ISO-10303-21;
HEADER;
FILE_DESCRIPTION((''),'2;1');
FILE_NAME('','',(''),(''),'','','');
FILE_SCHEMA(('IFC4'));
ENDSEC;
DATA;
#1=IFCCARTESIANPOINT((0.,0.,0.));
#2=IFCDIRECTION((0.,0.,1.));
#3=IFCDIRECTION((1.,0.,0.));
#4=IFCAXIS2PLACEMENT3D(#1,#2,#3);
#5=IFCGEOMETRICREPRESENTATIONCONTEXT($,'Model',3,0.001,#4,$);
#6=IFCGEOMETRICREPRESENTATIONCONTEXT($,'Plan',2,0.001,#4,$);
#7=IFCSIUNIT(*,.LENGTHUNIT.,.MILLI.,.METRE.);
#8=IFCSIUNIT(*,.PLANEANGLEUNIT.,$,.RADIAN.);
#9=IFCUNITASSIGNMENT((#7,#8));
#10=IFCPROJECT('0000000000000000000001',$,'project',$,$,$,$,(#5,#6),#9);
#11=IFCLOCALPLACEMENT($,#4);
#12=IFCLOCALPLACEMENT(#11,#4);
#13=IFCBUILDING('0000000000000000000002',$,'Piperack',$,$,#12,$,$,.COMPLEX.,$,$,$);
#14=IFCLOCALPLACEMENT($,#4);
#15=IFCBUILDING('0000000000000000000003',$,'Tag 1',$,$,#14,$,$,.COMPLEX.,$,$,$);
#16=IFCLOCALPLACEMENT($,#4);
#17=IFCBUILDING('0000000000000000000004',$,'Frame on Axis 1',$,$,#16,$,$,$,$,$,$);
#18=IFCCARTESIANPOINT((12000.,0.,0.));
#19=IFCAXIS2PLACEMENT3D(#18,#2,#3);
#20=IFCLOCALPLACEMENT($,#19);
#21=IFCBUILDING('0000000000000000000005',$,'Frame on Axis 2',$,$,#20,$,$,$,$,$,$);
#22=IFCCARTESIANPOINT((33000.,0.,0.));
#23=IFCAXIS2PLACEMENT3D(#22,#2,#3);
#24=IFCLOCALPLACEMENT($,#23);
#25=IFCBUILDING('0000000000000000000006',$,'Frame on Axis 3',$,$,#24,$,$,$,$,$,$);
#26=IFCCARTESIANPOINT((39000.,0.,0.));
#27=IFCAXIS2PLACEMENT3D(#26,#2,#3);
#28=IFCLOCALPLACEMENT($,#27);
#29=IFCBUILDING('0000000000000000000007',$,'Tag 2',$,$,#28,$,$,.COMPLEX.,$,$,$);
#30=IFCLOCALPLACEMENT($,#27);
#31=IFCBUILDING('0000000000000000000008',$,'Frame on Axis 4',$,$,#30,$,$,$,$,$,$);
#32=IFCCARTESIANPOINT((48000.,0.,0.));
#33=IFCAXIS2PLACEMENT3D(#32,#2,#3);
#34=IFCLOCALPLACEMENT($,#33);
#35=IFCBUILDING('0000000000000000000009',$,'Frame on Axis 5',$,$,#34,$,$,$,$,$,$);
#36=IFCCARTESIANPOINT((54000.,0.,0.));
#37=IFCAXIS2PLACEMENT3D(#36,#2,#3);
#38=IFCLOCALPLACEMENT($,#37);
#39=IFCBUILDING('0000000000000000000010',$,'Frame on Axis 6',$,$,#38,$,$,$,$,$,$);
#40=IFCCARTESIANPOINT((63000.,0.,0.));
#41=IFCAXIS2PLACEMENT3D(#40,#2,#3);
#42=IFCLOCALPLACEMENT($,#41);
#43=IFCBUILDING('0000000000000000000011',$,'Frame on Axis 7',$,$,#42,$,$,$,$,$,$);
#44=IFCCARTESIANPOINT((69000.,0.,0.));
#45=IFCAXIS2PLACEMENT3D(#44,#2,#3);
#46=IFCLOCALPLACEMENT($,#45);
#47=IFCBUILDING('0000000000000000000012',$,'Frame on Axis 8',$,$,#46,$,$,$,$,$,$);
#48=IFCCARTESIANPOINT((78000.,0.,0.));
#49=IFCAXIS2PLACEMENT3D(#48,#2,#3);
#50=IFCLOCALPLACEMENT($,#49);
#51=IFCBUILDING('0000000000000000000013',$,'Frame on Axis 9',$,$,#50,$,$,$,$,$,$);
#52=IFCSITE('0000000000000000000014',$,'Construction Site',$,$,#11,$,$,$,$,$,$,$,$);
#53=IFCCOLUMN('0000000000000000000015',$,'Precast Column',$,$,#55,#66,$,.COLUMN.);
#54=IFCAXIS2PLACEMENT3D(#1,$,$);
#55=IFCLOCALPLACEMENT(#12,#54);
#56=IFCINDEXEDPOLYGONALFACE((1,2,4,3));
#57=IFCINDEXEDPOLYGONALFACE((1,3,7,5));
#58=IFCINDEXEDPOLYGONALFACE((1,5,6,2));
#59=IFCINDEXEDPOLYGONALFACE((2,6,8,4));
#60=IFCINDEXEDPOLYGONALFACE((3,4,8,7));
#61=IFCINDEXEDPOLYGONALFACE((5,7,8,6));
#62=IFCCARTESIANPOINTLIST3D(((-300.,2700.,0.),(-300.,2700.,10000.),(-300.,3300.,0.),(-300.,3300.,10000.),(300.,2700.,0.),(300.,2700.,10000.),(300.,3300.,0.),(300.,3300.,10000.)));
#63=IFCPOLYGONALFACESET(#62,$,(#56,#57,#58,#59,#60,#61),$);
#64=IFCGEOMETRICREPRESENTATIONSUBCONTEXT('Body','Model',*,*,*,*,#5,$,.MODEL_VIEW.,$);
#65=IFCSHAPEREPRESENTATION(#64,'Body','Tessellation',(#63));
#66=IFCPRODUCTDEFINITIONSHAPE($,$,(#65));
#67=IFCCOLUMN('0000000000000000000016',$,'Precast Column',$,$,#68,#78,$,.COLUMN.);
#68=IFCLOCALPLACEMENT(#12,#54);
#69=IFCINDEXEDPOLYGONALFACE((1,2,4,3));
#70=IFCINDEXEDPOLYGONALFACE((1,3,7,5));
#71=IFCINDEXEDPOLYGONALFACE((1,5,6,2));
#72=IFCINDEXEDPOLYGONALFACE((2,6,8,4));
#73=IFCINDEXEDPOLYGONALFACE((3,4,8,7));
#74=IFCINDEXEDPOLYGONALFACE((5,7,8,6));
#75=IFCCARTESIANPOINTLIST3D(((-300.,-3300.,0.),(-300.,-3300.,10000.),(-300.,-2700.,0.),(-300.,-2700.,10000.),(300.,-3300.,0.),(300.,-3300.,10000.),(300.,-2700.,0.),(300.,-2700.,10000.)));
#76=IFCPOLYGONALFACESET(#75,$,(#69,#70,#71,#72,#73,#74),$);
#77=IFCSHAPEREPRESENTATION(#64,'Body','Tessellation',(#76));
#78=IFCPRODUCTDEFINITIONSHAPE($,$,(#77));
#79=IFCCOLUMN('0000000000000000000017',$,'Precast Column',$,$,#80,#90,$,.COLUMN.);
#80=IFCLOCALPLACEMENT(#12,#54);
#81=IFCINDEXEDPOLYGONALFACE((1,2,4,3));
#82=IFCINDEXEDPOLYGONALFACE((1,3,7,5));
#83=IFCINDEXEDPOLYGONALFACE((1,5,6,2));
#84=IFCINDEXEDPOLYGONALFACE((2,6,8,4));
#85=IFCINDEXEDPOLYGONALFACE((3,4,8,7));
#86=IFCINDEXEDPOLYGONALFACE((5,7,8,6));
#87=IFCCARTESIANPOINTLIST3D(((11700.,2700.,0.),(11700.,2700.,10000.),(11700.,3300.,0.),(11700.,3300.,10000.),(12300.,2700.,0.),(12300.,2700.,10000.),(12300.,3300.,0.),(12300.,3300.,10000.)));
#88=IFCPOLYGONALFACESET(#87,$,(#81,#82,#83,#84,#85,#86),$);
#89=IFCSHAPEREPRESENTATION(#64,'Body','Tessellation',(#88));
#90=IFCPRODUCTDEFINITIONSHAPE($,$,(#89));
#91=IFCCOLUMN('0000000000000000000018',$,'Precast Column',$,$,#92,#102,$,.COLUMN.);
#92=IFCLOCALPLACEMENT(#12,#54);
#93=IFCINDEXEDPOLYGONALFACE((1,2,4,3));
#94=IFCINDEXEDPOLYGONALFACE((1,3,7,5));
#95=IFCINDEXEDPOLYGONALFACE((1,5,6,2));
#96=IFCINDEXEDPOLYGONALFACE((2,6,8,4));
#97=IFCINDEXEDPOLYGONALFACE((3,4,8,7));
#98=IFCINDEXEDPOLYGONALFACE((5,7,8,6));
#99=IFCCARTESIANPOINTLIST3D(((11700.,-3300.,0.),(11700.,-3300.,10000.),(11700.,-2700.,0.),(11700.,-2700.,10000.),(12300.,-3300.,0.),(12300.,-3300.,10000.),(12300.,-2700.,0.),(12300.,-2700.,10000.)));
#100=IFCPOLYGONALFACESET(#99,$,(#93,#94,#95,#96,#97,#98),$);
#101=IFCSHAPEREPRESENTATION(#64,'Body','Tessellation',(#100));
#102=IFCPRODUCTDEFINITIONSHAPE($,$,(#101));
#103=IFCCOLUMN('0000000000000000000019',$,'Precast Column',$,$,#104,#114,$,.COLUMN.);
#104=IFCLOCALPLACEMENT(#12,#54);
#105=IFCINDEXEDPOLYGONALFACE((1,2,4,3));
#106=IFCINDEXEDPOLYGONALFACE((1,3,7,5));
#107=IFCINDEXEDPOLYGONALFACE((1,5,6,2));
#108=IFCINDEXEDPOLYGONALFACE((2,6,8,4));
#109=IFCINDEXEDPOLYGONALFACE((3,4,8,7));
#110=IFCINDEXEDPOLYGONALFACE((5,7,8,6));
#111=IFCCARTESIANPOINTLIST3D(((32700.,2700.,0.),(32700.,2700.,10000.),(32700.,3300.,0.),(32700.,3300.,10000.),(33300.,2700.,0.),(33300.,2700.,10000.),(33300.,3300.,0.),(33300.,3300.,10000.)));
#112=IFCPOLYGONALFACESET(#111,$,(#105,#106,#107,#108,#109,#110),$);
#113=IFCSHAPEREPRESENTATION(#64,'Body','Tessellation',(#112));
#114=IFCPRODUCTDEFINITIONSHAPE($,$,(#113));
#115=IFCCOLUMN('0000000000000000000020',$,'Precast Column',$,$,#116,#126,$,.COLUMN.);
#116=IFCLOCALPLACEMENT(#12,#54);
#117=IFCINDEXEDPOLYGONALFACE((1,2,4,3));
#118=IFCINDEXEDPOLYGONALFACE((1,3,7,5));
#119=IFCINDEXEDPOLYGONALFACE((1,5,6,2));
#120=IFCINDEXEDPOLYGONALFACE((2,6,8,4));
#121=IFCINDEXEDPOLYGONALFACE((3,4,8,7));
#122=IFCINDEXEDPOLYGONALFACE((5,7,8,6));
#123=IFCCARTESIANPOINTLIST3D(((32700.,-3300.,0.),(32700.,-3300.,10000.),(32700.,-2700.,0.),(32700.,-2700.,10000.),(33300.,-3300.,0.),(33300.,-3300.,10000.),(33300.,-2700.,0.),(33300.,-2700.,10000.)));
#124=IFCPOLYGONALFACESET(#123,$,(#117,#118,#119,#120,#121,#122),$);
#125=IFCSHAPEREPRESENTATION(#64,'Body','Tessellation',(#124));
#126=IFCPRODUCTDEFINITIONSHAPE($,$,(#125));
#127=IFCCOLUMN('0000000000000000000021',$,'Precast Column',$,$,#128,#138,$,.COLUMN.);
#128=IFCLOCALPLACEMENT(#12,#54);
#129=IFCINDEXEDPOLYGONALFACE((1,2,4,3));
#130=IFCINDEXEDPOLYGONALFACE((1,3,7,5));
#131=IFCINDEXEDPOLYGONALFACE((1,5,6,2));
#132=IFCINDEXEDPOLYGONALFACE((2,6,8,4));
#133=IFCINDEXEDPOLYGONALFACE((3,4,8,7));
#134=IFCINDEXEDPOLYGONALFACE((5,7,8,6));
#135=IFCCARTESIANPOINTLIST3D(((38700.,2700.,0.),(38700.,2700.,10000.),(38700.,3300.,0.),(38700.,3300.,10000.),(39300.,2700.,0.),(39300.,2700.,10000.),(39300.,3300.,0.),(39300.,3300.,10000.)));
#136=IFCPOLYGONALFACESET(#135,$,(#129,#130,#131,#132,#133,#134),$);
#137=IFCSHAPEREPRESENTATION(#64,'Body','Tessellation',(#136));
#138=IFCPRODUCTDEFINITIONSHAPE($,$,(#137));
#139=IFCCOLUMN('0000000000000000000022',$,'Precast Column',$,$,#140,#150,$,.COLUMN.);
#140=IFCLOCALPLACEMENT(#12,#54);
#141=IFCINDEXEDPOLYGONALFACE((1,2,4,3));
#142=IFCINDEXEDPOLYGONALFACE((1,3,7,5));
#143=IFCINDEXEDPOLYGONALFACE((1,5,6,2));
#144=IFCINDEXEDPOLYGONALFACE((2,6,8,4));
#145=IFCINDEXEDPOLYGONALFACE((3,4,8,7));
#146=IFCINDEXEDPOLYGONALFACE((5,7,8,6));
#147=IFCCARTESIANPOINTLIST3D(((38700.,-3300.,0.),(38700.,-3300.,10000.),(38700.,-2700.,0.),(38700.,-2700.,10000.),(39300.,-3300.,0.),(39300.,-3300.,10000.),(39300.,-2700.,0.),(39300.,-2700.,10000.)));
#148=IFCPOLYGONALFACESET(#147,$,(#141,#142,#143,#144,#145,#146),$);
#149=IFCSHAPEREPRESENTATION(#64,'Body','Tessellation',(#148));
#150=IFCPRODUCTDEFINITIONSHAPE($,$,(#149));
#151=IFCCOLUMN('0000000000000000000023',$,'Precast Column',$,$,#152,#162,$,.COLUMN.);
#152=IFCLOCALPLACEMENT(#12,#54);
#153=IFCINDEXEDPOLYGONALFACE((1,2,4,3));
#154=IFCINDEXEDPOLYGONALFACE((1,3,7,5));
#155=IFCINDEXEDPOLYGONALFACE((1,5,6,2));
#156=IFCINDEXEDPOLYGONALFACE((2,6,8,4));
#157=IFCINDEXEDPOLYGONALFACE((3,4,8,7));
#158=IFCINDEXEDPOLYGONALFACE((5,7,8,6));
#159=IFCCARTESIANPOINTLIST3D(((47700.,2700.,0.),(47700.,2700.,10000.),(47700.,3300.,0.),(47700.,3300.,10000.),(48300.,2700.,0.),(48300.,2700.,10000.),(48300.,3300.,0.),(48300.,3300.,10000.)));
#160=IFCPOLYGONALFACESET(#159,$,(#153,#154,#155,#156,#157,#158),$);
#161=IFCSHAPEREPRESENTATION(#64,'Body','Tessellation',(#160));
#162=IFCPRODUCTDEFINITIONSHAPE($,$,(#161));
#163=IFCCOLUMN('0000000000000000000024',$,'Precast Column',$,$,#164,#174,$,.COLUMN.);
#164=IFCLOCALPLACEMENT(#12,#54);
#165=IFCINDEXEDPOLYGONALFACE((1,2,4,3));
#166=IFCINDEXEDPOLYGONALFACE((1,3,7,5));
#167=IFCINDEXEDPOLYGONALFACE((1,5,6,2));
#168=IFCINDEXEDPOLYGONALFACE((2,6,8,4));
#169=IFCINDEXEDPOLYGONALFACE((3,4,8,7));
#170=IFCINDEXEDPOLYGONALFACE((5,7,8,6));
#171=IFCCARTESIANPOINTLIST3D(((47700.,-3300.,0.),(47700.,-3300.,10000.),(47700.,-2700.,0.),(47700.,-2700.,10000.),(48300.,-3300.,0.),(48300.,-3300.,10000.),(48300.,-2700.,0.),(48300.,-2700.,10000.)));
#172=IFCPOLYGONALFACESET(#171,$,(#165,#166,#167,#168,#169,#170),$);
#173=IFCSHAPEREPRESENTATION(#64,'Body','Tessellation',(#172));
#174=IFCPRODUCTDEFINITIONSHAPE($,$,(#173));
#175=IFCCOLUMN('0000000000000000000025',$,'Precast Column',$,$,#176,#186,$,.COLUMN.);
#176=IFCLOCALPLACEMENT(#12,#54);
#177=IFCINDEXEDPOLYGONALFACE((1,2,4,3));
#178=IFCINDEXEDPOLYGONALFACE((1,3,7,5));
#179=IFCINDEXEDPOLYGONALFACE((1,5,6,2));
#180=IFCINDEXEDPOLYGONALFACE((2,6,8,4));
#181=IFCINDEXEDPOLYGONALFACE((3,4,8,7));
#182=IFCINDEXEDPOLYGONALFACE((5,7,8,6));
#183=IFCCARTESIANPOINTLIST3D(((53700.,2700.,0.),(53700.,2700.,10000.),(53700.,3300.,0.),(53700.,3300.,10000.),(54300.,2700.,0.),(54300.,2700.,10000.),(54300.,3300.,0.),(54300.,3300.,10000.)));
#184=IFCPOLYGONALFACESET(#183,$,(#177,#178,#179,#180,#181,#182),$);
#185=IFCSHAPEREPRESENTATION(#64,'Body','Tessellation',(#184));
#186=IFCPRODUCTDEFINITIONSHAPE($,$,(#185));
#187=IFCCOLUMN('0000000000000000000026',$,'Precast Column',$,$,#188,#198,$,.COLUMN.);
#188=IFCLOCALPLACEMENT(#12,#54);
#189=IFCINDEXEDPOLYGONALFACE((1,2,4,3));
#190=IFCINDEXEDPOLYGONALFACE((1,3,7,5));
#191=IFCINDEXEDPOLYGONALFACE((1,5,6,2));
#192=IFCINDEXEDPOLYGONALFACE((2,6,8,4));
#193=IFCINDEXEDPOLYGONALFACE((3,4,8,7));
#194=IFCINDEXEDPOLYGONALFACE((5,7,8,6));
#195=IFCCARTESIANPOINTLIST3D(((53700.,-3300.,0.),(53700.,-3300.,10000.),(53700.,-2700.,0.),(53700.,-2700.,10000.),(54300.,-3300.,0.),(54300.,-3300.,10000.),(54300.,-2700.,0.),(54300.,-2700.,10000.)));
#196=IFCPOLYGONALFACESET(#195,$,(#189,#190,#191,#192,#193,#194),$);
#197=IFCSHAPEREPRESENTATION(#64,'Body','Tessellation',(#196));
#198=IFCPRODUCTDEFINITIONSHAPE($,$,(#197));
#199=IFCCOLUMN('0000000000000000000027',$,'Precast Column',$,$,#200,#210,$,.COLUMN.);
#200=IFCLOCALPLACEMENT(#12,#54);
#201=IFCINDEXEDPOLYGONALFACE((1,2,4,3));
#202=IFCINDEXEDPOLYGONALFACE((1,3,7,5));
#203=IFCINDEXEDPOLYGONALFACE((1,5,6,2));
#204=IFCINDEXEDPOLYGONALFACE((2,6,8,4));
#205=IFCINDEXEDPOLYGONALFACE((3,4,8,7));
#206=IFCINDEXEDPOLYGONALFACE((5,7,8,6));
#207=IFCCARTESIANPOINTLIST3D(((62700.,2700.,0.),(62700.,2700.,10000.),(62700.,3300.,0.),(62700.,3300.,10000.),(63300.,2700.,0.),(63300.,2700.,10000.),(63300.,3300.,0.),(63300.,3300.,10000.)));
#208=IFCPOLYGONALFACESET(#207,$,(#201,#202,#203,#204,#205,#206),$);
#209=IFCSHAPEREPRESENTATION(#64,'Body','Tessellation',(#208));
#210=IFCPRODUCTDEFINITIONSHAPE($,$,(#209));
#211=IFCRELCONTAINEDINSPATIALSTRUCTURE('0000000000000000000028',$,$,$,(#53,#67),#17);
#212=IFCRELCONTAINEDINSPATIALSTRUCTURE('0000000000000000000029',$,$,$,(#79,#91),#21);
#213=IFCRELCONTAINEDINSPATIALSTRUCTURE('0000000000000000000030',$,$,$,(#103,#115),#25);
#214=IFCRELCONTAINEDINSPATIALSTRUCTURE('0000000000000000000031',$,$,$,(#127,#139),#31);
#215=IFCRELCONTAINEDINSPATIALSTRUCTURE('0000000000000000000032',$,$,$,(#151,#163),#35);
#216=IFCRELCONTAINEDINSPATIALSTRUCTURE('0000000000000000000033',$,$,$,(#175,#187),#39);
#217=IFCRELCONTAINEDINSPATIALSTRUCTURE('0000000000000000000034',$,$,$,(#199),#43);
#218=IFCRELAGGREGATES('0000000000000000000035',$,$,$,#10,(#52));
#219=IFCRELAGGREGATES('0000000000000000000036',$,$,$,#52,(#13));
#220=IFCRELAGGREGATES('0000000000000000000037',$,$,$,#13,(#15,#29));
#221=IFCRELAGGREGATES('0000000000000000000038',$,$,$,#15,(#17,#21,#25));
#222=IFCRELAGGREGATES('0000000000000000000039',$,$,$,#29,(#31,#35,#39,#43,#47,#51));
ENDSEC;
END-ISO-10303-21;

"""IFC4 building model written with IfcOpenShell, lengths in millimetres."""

from ifc_helpers import new_model, si_unit, frame, origin_with_axes, place, context, subcontext, project, spatial, rectangle, extrude, element, save


model = new_model("IFC4")

# Units and contexts
model_context = context("Model", 3, precision=0.001, world=origin_with_axes())
plan_context = context("Plan", 2, precision=0.001, world=origin_with_axes())
body_context = subcontext(model_context, "Body", "Model", "MODEL_VIEW")
ifc_project = project(units=[si_unit("LENGTHUNIT", "METRE", prefix="MILLI"), si_unit("PLANEANGLEUNIT", "RADIAN")], contexts=[model_context, plan_context])

# Site, buildings
site_placement = place(None, origin_with_axes())
site = spatial("IfcSite", under=ifc_project, at=site_placement, Name="Construction Site")
building_1_placement = place(site_placement, origin_with_axes())
building_1 = spatial("IfcBuilding", under=site, at=building_1_placement, Name="Piperack", CompositionType="COMPLEX")
building_2_placement = place(None, origin_with_axes())
building_2 = spatial("IfcBuilding", under=building_1, at=building_2_placement, Name="Tag 1", CompositionType="COMPLEX")
building_3_placement = place(None, origin_with_axes())
building_3 = spatial("IfcBuilding", under=building_2, at=building_3_placement, Name="Frame on Axis 1")

# Columns
for number, where, z_axis, x_axis, name in (
    (1, (0.0, 3000.0, 0.0), (0.0, 0.0, 1.0), (1.0, 0.0, 0.0), "Precast Column"),
    (2, (0.0, -3000.0, 0.0), (0.0, 0.0, 1.0), (1.0, 0.0, 0.0), "Precast Column"),
):
    element("IfcColumn", number, at=place(building_3_placement, frame(where, z_axis=z_axis, x_axis=x_axis)), inside=building_3, Name=name, PredefinedType="COLUMN", context=body_context, shape_type="SweptSolid", body=[
        extrude(rectangle(XDim=600.0, YDim=600.0), None, (0.0, 0.0, 1.0), 10000.0),
    ])

# Shared definitions
building_4_placement = place(None, frame((12000.0, 0.0, 0.0), z_axis=(0.0, 0.0, 1.0), x_axis=(1.0, 0.0, 0.0)))
building_4 = spatial("IfcBuilding", under=building_2, at=building_4_placement, Name="Frame on Axis 2")

# Columns
for number, where, z_axis, x_axis, name in (
    (3, (0.0, 3000.0, 0.0), (0.0, 0.0, 1.0), (1.0, 0.0, 0.0), "Precast Column"),
    (4, (0.0, -3000.0, 0.0), (0.0, 0.0, 1.0), (1.0, 0.0, 0.0), "Precast Column"),
):
    element("IfcColumn", number, at=place(building_4_placement, frame(where, z_axis=z_axis, x_axis=x_axis)), inside=building_4, Name=name, PredefinedType="COLUMN", context=body_context, shape_type="SweptSolid", body=[
        extrude(rectangle(XDim=600.0, YDim=600.0), None, (0.0, 0.0, 1.0), 10000.0),
    ])

# Shared definitions
building_5_placement = place(None, frame((33000.0, 0.0, 0.0), z_axis=(0.0, 0.0, 1.0), x_axis=(1.0, 0.0, 0.0)))
building_5 = spatial("IfcBuilding", under=building_2, at=building_5_placement, Name="Frame on Axis 3")

# Columns
for number, where, z_axis, x_axis, name in (
    (5, (0.0, 3000.0, 0.0), (0.0, 0.0, 1.0), (1.0, 0.0, 0.0), "Precast Column"),
    (6, (0.0, -3000.0, 0.0), (0.0, 0.0, 1.0), (1.0, 0.0, 0.0), "Precast Column"),
):
    element("IfcColumn", number, at=place(building_5_placement, frame(where, z_axis=z_axis, x_axis=x_axis)), inside=building_5, Name=name, PredefinedType="COLUMN", context=body_context, shape_type="SweptSolid", body=[
        extrude(rectangle(XDim=600.0, YDim=600.0), None, (0.0, 0.0, 1.0), 10000.0),
    ])

# Shared definitions
building_6_placement = place(None, frame((39000.0, 0.0, 0.0), z_axis=(0.0, 0.0, 1.0), x_axis=(1.0, 0.0, 0.0)))
building_6 = spatial("IfcBuilding", under=building_1, at=building_6_placement, Name="Tag 2", CompositionType="COMPLEX")
building_7_placement = place(None, frame((39000.0, 0.0, 0.0), z_axis=(0.0, 0.0, 1.0), x_axis=(1.0, 0.0, 0.0)))
building_7 = spatial("IfcBuilding", under=building_6, at=building_7_placement, Name="Frame on Axis 4")

# Columns
for number, where, z_axis, x_axis, name in (
    (7, (0.0, 3000.0, 0.0), (0.0, 0.0, 1.0), (1.0, 0.0, 0.0), "Precast Column"),
    (8, (0.0, -3000.0, 0.0), (0.0, 0.0, 1.0), (1.0, 0.0, 0.0), "Precast Column"),
):
    element("IfcColumn", number, at=place(building_7_placement, frame(where, z_axis=z_axis, x_axis=x_axis)), inside=building_7, Name=name, PredefinedType="COLUMN", context=body_context, shape_type="SweptSolid", body=[
        extrude(rectangle(XDim=600.0, YDim=600.0), None, (0.0, 0.0, 1.0), 10000.0),
    ])

# Shared definitions
building_8_placement = place(None, frame((48000.0, 0.0, 0.0), z_axis=(0.0, 0.0, 1.0), x_axis=(1.0, 0.0, 0.0)))
building_8 = spatial("IfcBuilding", under=building_6, at=building_8_placement, Name="Frame on Axis 5")

# Columns
for number, where, z_axis, x_axis, name in (
    (9, (0.0, 3000.0, 0.0), (0.0, 0.0, 1.0), (1.0, 0.0, 0.0), "Precast Column"),
    (10, (0.0, -3000.0, 0.0), (0.0, 0.0, 1.0), (1.0, 0.0, 0.0), "Precast Column"),
):
    element("IfcColumn", number, at=place(building_8_placement, frame(where, z_axis=z_axis, x_axis=x_axis)), inside=building_8, Name=name, PredefinedType="COLUMN", context=body_context, shape_type="SweptSolid", body=[
        extrude(rectangle(XDim=600.0, YDim=600.0), None, (0.0, 0.0, 1.0), 10000.0),
    ])

# Shared definitions
building_9_placement = place(None, frame((54000.0, 0.0, 0.0), z_axis=(0.0, 0.0, 1.0), x_axis=(1.0, 0.0, 0.0)))
building_9 = spatial("IfcBuilding", under=building_6, at=building_9_placement, Name="Frame on Axis 6")

# Columns
for number, where, z_axis, x_axis, name in (
    (11, (0.0, 3000.0, 0.0), (0.0, 0.0, 1.0), (1.0, 0.0, 0.0), "Precast Column"),
    (12, (0.0, -3000.0, 0.0), (0.0, 0.0, 1.0), (1.0, 0.0, 0.0), "Precast Column"),
):
    element("IfcColumn", number, at=place(building_9_placement, frame(where, z_axis=z_axis, x_axis=x_axis)), inside=building_9, Name=name, PredefinedType="COLUMN", context=body_context, shape_type="SweptSolid", body=[
        extrude(rectangle(XDim=600.0, YDim=600.0), None, (0.0, 0.0, 1.0), 10000.0),
    ])

# Shared definitions
building_10_placement = place(None, frame((63000.0, 0.0, 0.0), z_axis=(0.0, 0.0, 1.0), x_axis=(1.0, 0.0, 0.0)))
building_10 = spatial("IfcBuilding", under=building_6, at=building_10_placement, Name="Frame on Axis 7")

# Column
for number, where, z_axis, x_axis, name in (
    (13, (0.0, 3000.0, 0.0), (0.0, 0.0, 1.0), (1.0, 0.0, 0.0), "Precast Column"),
):
    element("IfcColumn", number, at=place(building_10_placement, frame(where, z_axis=z_axis, x_axis=x_axis)), inside=building_10, Name=name, PredefinedType="COLUMN", context=body_context, shape_type="SweptSolid", body=[
        extrude(rectangle(XDim=600.0, YDim=600.0), None, (0.0, 0.0, 1.0), 10000.0),
    ])

# Shared definitions
building_11_placement = place(None, frame((69000.0, 0.0, 0.0), z_axis=(0.0, 0.0, 1.0), x_axis=(1.0, 0.0, 0.0)))
building_11 = spatial("IfcBuilding", under=building_6, at=building_11_placement, Name="Frame on Axis 8")

# Shared definitions
building_12_placement = place(None, frame((78000.0, 0.0, 0.0), z_axis=(0.0, 0.0, 1.0), x_axis=(1.0, 0.0, 0.0)))
building_12 = spatial("IfcBuilding", under=building_6, at=building_12_placement, Name="Frame on Axis 9")

save(model, "model.ifc")
